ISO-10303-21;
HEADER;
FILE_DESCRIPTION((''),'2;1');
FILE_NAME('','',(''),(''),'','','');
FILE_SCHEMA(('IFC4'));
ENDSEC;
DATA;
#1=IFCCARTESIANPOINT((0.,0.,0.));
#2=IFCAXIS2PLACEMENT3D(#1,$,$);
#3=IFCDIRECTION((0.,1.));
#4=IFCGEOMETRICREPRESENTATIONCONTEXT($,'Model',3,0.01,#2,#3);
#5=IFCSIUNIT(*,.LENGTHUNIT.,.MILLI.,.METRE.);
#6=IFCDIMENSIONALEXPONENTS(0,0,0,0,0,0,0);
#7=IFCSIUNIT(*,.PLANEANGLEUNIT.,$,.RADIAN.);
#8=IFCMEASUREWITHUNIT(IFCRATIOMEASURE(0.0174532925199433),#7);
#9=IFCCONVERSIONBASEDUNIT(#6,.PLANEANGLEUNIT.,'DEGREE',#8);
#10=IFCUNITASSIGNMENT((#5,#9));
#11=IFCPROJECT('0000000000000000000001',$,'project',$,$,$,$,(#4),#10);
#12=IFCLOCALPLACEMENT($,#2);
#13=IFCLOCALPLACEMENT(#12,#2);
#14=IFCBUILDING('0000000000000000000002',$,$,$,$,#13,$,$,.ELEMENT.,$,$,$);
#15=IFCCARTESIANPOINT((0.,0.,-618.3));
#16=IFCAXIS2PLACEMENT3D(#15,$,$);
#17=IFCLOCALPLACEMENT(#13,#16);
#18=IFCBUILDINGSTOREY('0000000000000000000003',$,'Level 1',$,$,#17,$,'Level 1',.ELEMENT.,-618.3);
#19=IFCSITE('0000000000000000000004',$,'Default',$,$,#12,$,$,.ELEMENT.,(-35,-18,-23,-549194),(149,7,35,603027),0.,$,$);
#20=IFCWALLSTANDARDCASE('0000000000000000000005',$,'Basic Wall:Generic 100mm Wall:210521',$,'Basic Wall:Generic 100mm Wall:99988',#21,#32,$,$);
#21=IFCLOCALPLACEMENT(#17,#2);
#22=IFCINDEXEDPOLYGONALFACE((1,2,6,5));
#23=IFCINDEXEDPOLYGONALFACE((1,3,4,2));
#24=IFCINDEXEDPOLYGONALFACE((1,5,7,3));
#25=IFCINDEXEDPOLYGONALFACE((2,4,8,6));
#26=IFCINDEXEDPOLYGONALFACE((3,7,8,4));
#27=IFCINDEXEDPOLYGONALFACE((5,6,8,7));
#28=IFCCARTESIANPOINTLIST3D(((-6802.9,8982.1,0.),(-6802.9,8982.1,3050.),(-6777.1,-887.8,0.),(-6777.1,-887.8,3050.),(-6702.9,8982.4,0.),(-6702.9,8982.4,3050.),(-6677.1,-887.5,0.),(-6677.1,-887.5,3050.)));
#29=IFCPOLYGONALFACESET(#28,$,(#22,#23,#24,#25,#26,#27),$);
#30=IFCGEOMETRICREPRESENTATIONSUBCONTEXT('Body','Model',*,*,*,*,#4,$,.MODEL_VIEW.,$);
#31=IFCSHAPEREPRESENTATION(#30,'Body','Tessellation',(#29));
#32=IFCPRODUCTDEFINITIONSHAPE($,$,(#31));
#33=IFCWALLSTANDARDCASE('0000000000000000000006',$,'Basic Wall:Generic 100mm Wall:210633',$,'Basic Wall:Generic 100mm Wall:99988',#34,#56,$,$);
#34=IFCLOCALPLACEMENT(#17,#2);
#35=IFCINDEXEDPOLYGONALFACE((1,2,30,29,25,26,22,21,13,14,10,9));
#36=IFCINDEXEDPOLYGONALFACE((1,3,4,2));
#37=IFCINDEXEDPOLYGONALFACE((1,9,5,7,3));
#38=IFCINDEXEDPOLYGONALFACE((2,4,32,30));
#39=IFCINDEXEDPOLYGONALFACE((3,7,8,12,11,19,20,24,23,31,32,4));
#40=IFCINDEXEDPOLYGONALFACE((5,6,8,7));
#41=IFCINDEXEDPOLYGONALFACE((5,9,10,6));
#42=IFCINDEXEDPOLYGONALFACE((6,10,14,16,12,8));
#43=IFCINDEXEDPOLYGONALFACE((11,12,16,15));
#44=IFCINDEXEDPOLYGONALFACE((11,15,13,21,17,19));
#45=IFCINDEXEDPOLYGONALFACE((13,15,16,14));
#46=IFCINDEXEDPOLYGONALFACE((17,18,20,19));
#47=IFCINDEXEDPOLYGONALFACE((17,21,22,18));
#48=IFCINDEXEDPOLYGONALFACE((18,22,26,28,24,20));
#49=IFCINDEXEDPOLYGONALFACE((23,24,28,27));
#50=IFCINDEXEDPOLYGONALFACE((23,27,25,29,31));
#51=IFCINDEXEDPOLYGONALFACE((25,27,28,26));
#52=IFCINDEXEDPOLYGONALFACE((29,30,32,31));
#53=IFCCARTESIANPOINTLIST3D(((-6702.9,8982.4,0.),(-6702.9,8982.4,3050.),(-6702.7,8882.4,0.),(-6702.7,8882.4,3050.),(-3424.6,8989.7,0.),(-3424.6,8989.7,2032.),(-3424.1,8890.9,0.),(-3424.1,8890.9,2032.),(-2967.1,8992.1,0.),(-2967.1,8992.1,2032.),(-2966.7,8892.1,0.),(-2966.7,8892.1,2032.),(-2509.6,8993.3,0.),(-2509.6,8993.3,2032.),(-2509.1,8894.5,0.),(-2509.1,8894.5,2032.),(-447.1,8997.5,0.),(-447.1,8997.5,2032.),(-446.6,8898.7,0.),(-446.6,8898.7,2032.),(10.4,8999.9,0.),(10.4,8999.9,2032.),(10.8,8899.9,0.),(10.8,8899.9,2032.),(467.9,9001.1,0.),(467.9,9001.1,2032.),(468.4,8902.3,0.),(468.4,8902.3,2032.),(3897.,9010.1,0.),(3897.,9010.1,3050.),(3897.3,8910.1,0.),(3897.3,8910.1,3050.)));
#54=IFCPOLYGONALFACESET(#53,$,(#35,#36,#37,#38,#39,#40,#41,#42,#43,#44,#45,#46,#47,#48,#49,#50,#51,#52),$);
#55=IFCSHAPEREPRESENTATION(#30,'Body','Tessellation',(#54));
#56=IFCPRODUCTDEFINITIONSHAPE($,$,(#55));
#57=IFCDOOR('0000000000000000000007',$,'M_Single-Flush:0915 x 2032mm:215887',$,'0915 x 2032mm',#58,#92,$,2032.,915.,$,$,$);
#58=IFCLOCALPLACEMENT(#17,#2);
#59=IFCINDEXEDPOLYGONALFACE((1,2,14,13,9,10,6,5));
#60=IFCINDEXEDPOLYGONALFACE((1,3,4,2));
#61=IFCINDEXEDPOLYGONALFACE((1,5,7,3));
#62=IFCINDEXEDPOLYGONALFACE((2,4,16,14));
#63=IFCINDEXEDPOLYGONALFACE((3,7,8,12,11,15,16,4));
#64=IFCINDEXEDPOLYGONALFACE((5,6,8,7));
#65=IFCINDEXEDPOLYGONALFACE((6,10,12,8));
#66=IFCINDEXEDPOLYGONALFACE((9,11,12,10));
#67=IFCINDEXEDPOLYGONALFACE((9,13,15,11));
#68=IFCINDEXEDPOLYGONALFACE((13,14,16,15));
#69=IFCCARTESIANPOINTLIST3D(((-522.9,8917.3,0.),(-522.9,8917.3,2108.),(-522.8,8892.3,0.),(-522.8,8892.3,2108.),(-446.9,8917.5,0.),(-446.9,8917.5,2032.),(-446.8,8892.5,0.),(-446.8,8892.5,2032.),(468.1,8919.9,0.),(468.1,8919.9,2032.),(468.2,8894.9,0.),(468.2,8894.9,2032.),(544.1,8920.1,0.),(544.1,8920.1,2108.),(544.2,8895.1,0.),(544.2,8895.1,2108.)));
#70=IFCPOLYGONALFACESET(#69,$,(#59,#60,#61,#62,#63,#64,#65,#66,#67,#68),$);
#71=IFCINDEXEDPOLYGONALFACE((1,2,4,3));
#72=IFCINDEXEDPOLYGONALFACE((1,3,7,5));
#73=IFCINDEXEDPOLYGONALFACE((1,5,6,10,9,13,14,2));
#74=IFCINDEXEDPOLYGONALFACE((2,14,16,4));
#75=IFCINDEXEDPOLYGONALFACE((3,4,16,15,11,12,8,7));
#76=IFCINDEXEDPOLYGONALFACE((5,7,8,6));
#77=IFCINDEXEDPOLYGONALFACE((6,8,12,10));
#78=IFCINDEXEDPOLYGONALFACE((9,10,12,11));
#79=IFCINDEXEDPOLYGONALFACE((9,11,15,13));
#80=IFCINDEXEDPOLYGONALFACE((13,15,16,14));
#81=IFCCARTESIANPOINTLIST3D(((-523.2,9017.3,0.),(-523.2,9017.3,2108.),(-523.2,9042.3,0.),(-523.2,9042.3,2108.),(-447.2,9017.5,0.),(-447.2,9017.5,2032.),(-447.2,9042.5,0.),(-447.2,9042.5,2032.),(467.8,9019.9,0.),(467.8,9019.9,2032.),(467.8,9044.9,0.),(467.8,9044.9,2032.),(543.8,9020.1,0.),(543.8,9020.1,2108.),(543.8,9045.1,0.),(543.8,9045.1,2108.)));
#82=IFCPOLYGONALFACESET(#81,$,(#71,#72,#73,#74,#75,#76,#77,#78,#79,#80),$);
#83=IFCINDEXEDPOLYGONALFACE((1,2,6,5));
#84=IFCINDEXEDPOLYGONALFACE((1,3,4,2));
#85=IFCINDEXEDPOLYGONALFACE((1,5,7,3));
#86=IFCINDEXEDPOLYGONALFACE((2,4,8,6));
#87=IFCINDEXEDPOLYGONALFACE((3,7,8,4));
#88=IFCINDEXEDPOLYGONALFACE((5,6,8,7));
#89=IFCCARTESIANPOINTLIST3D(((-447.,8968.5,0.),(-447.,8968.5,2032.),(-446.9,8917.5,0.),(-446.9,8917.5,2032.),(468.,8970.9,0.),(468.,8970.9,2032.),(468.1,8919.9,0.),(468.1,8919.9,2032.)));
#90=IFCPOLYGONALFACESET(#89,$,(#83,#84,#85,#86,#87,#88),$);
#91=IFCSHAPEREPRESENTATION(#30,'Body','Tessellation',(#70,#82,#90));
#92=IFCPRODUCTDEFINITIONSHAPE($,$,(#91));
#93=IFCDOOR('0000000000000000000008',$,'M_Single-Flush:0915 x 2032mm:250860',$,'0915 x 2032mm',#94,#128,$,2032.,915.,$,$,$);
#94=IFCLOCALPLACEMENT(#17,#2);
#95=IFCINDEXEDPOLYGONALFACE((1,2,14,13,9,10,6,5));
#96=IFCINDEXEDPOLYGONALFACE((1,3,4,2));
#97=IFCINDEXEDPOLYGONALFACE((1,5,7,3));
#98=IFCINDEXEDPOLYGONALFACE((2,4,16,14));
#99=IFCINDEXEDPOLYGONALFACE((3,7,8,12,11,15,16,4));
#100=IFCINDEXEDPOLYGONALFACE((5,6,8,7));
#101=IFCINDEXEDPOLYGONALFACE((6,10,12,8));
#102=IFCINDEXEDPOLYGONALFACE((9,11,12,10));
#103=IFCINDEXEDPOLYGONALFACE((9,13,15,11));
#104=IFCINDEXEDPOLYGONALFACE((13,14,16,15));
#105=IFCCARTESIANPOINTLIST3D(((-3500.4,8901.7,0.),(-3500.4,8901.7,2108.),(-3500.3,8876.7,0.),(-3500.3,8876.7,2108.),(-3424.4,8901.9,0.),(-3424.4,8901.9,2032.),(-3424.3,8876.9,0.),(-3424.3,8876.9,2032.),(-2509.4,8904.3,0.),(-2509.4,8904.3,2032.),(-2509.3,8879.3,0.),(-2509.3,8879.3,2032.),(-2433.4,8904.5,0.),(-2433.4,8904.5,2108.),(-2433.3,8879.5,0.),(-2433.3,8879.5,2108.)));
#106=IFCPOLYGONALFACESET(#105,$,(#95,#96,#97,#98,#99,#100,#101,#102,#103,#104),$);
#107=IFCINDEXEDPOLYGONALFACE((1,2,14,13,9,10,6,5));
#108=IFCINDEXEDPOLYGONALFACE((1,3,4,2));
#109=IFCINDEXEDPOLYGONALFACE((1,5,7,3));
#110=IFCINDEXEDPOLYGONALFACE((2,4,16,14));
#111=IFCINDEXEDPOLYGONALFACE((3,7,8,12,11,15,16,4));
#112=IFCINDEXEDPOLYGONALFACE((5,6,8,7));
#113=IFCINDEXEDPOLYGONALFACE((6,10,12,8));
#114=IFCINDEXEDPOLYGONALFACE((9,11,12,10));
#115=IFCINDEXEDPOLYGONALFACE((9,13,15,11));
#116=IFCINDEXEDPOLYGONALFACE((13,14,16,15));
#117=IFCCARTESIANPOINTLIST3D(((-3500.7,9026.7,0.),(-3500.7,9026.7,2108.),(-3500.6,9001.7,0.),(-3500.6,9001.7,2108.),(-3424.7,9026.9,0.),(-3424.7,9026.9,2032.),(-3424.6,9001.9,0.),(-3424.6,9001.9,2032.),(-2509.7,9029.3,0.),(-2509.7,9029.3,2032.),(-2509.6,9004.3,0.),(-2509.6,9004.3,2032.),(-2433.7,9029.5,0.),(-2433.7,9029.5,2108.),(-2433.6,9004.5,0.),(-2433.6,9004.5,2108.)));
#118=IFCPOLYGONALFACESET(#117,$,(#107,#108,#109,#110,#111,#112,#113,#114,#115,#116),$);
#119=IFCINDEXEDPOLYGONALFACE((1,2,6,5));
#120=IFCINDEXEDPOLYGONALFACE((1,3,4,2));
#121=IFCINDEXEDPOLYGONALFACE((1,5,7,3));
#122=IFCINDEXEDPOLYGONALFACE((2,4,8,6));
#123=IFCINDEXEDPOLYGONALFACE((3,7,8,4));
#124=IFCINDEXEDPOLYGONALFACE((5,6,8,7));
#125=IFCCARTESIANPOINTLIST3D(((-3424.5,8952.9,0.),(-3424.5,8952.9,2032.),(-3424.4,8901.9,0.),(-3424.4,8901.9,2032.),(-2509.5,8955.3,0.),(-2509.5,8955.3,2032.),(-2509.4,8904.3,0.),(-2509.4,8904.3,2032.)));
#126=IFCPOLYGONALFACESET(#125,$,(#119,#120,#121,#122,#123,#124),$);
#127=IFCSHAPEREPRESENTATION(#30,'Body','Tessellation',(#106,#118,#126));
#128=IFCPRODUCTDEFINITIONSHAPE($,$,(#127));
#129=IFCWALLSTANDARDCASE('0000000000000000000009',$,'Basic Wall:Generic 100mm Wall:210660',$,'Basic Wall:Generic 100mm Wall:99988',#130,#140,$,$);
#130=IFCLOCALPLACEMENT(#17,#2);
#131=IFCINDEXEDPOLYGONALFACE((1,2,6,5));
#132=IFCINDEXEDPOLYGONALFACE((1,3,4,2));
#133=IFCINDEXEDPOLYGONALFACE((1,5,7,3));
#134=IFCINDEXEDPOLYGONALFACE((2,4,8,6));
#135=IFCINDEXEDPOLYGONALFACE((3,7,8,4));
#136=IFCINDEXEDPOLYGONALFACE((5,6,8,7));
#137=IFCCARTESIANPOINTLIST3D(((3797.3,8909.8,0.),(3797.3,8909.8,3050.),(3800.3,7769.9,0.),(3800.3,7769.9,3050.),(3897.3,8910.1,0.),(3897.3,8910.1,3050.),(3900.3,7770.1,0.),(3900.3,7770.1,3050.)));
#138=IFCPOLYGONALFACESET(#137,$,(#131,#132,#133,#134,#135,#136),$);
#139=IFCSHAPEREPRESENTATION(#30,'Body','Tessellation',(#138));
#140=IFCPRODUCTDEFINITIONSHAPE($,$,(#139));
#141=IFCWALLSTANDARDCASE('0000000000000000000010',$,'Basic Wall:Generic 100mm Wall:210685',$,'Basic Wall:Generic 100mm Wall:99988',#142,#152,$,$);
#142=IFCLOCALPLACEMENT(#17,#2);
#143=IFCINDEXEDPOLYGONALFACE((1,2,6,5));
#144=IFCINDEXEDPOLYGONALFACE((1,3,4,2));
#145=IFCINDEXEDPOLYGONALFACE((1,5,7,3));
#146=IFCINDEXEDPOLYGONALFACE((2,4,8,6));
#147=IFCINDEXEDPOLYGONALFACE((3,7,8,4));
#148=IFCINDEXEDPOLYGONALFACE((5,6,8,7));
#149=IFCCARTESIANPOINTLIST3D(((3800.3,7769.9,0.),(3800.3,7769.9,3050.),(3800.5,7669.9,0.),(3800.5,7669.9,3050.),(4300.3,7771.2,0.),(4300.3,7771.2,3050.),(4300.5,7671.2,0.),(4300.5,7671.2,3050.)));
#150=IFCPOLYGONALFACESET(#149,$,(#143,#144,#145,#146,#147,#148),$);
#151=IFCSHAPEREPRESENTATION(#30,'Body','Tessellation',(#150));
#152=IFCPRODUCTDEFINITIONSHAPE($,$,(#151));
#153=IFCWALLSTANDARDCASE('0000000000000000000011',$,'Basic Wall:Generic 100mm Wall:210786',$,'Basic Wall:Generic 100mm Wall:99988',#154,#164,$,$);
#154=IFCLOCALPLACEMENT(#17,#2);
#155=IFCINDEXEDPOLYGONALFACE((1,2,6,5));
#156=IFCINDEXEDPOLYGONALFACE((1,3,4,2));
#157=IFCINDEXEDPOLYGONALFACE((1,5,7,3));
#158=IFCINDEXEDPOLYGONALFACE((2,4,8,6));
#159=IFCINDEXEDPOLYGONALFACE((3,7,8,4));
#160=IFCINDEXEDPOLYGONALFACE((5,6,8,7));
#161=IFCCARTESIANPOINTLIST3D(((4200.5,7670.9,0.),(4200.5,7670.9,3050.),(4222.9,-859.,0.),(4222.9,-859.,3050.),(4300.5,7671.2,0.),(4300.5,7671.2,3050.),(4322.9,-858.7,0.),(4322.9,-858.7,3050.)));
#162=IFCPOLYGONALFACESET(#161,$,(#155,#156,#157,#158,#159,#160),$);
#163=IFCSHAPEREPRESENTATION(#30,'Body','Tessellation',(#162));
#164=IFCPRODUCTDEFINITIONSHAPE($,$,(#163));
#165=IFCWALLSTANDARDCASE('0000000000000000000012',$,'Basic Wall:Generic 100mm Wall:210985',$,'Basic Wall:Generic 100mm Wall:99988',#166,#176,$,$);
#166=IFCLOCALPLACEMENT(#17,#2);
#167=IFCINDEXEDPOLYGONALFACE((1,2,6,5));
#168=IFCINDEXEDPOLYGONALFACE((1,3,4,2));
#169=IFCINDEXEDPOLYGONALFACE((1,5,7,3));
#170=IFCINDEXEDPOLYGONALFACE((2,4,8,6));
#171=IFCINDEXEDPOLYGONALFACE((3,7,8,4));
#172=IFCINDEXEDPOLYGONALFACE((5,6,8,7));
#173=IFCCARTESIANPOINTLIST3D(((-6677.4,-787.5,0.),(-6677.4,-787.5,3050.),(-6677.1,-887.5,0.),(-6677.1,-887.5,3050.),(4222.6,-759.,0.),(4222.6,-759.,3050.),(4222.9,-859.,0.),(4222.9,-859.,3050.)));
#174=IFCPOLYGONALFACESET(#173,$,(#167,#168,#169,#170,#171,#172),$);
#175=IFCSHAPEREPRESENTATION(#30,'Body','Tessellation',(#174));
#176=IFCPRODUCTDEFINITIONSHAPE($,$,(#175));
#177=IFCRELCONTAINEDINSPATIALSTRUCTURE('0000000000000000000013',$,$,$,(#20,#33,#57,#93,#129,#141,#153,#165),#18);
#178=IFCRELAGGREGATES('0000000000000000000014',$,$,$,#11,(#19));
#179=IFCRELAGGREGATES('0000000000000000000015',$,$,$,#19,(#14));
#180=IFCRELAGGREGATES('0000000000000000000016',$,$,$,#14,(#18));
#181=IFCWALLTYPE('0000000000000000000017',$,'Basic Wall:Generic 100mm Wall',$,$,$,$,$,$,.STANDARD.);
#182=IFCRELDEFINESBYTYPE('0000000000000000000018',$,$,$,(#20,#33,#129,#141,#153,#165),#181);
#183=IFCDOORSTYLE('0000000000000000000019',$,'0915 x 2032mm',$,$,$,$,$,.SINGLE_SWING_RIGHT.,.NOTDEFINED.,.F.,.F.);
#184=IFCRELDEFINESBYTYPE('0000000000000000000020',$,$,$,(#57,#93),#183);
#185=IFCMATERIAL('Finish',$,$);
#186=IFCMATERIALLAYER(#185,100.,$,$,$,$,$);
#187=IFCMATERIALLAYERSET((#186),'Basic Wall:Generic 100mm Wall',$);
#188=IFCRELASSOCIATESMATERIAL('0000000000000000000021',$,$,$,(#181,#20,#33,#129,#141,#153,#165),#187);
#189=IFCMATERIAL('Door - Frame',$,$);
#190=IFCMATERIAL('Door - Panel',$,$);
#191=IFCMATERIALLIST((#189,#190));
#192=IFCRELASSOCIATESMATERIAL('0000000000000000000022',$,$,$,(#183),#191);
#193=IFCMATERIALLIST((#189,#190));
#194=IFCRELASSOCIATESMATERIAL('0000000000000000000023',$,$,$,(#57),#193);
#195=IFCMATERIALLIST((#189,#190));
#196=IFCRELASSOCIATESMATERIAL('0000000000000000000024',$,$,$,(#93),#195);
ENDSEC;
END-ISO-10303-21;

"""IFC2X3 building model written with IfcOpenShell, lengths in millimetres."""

from ifc_helpers import new_model, entity, si_unit, converted_unit, direction, frame, frame_2d, origin, origin_2d_with_axis, place, context, subcontext, project, spatial, polyline, rectangle, outline, extrude, source, transform, mapped, material, material_list, layer, layer_set, layer_usage, type_object, type_shapes, element, fill, save


model = new_model("IFC2X3")

# Units and contexts
model_context = context("Model", 3, precision=0.01, world=origin(), true_north=direction((0.0, 1.0)))
body_context = subcontext(model_context, "Body", "Model", "MODEL_VIEW")
ifc_project = project(units=[si_unit("LENGTHUNIT", "METRE", prefix="MILLI"), converted_unit("PLANEANGLEUNIT", "DEGREE", entity("IfcRatioMeasure", 0.0174532925199433), si_unit("PLANEANGLEUNIT", "RADIAN"), dimensions=[0, 0, 0, 0, 0, 0, 0])], contexts=[model_context])

# Site, building, storey
site_placement = place(None, origin())
site = spatial("IfcSite", under=ifc_project, at=site_placement, Name="Default", CompositionType="ELEMENT", RefLatitude=(-35, -18, -23, -549194), RefLongitude=(149, 7, 35, 603027), RefElevation=0.0)
building_placement = place(site_placement, origin())
building = spatial("IfcBuilding", under=site, at=building_placement, CompositionType="ELEMENT")
storey_placement = place(building_placement, frame((0.0, 0.0, -618.3)))
storey = spatial("IfcBuildingStorey", under=building, at=storey_placement, Name="Level 1", LongName="Level 1", CompositionType="ELEMENT", Elevation=-618.3)

# Wall
ifc_material_1 = material(Name="Finish")
ifc_layer_1 = layer(ifc_material_1, 100.0)
ifc_layer_set_1 = layer_set([ifc_layer_1], Name="Basic Wall:Generic 100mm Wall")
ifc_layer_usage_1 = layer_usage(ifc_layer_set_1, "AXIS2", "NEGATIVE", 50.0)
wall_type = type_object("IfcWallType", Name="Basic Wall:Generic 100mm Wall", PredefinedType="STANDARD", material=ifc_layer_set_1)
wall_1_placement = place(storey_placement, frame((-6727.1, -887.7, 0.0), z_axis=(0.0, 0.0, 1.0), x_axis=(-0.002618, 0.999997, 0.0)))
element("IfcWallStandardCase", 1, at=wall_1_placement, inside=storey, type_object=wall_type, material=ifc_layer_usage_1, Name="Basic Wall:Generic 100mm Wall:210521", ObjectType="Basic Wall:Generic 100mm Wall:99988", context=body_context, shape_type="SweptSolid", body=[
    extrude(rectangle(XDim=9869.9, YDim=100.0, at=frame_2d((4935.0, 0.0), x_axis=(-1.0, 0.0))), origin(), (0.0, 0.0, 1.0), 3050.0),
])

# Wall, openings, doors
ifc_layer_usage_2 = layer_usage(ifc_layer_set_1, "AXIS2", "NEGATIVE", 50.0)
wall_2_placement = place(storey_placement, frame((-6702.8, 8932.4, 0.0), z_axis=(0.0, 0.0, 1.0), x_axis=(0.999997, 0.002618, 0.0)))
wall_2 = element("IfcWallStandardCase", 2, at=wall_2_placement, inside=storey, type_object=wall_type, material=ifc_layer_usage_2, Name="Basic Wall:Generic 100mm Wall:210633", ObjectType="Basic Wall:Generic 100mm Wall:99988", context=body_context, shape_type="SweptSolid", body=[
    extrude(rectangle(XDim=10600.0, YDim=100.0, at=frame_2d((5300.0, 0.0), x_axis=(-1.0, 0.0))), origin(), (0.0, 0.0, 1.0), 3050.0),
])
opening_1_placement = place(wall_2_placement, frame((7170.8, 51.2, 0.0)))
opening_1 = element("IfcOpeningElement", 3, at=opening_1_placement, cuts=wall_2, ObjectType="Opening", context=body_context, shape_type="SweptSolid", body=[
    extrude(rectangle(XDim=915.0, YDim=2032.0, at=frame_2d((1016.0, 457.5), x_axis=(0.0, 1.0))), frame((0.0, 0.0, 0.0), z_axis=(0.002618, -0.999997, 0.0), x_axis=(0.0, 0.0, 1.0)), (0.0, 0.0, 1.0), 100.0),
])
opening_2_placement = place(wall_2_placement, frame((4193.4, 51.2, 0.0)))
opening_2 = element("IfcOpeningElement", 4, at=opening_2_placement, cuts=wall_2, ObjectType="Opening", context=body_context, shape_type="SweptSolid", body=[
    extrude(rectangle(XDim=915.0, YDim=2032.0, at=frame_2d((1016.0, 457.5), x_axis=(0.0, 1.0))), frame((0.0, 0.0, 0.0), z_axis=(0.002618, -0.999997, 0.0), x_axis=(0.0, 0.0, 1.0)), (0.0, 0.0, 1.0), 100.0),
])
ifc_material_2 = material(Name="Door - Frame")
ifc_material_3 = material(Name="Door - Panel")
ifc_material_list_1 = material_list([ifc_material_2, ifc_material_3])
ifc_material_list_2 = material_list([ifc_material_2, ifc_material_3])
door_style = type_object("IfcDoorStyle", Name="0915 x 2032mm", ConstructionType="NOTDEFINED", OperationType="SINGLE_SWING_RIGHT", ParameterTakesPrecedence=False, Sizeable=False, material=ifc_material_list_2)
shared_shape = source(origin(), body_context, "Body", "SweptSolid", [
    extrude(outline(polyline([(-533.5, -1073.0), (533.5, -1073.0), (533.5, 1035.0), (457.5, 1035.0), (457.5, -997.0), (-457.5, -997.0), (-457.5, 1035.0), (-533.5, 1035.0), (-533.5, -1073.0)])), frame((457.5, 100.0, 1035.0), z_axis=(0.0, 1.0, 0.0), x_axis=(1.0, 0.0, 0.0)), (0.0, 0.0, 1.0), 25.0),
    extrude(outline(polyline([(-1073.0, -533.5), (1035.0, -533.5), (1035.0, -457.5), (-997.0, -457.5), (-997.0, 457.5), (1035.0, 457.5), (1035.0, 533.5), (-1073.0, 533.5), (-1073.0, -533.5)])), frame((457.5, -25.0, 1035.0), z_axis=(0.0, 1.0, 0.0), x_axis=(0.0, 0.0, -1.0)), (0.0, 0.0, 1.0), 25.0),
    extrude(rectangle(XDim=51.0, YDim=915.0, at=origin_2d_with_axis()), frame((457.5, 74.5, 0.0), z_axis=(0.0, 0.0, 1.0), x_axis=(0.0, 1.0, 0.0)), (0.0, 0.0, 1.0), 2032.0),
])
type_shapes(door_style, [shared_shape])
door_1_placement = place(opening_1_placement, frame((0.0, 17.6, 0.0), z_axis=(0.0, 0.0, 1.0), x_axis=(-1.0, 0.0, 0.0)))
door_1 = element("IfcDoor", 5, at=door_1_placement, inside=storey, type_object=door_style, material=ifc_material_list_1, Name="M_Single-Flush:0915 x 2032mm:215887", ObjectType="0915 x 2032mm", OverallHeight=2032.0, OverallWidth=915.0, context=body_context, shape_type="MappedRepresentation", body=[
    mapped(shared_shape, transform((0.0, 0.0, 0.0), scale=1.0)),
])
fill(opening_1, door_1)
ifc_material_list_3 = material_list([ifc_material_2, ifc_material_3])
door_2_placement = place(opening_2_placement, frame((0.0, 9.8, 0.0), z_axis=(0.0, 0.0, 1.0), x_axis=(-1.0, 0.0, 0.0)))
door_2 = element("IfcDoor", 6, at=door_2_placement, inside=storey, type_object=door_style, material=ifc_material_list_3, Name="M_Single-Flush:0915 x 2032mm:250860", ObjectType="0915 x 2032mm", OverallHeight=2032.0, OverallWidth=915.0, context=body_context, shape_type="MappedRepresentation", body=[
    mapped(shared_shape, transform((0.0, 0.0, 0.0), scale=1.0)),
])
fill(opening_2, door_2)

# Walls
ifc_layer_usage_3 = layer_usage(ifc_layer_set_1, "AXIS2", "NEGATIVE", 50.0)
wall_3_placement = place(storey_placement, frame((3847.3, 8910.0, 0.0), z_axis=(0.0, 0.0, 1.0), x_axis=(0.002618, -0.999997, 0.0)))
element("IfcWallStandardCase", 7, at=wall_3_placement, inside=storey, type_object=wall_type, material=ifc_layer_usage_3, Name="Basic Wall:Generic 100mm Wall:210660", ObjectType="Basic Wall:Generic 100mm Wall:99988", context=body_context, shape_type="SweptSolid", body=[
    extrude(rectangle(XDim=1140.0, YDim=100.0, at=frame_2d((570.0, 0.0), x_axis=(-1.0, 0.0))), origin(), (0.0, 0.0, 1.0), 3050.0),
])
ifc_layer_usage_4 = layer_usage(ifc_layer_set_1, "AXIS2", "NEGATIVE", 50.0)
wall_4_placement = place(storey_placement, frame((3800.4, 7719.9, 0.0), z_axis=(0.0, 0.0, 1.0), x_axis=(0.999997, 0.002618, 0.0)))
element("IfcWallStandardCase", 8, at=wall_4_placement, inside=storey, type_object=wall_type, material=ifc_layer_usage_4, Name="Basic Wall:Generic 100mm Wall:210685", ObjectType="Basic Wall:Generic 100mm Wall:99988", context=body_context, shape_type="SweptSolid", body=[
    extrude(rectangle(XDim=500.0, YDim=100.0, at=frame_2d((250.0, 0.0), x_axis=(-1.0, 0.0))), origin(), (0.0, 0.0, 1.0), 3050.0),
])
ifc_layer_usage_5 = layer_usage(ifc_layer_set_1, "AXIS2", "NEGATIVE", 50.0)
wall_5_placement = place(storey_placement, frame((4250.5, 7671.0, 0.0), z_axis=(0.0, 0.0, 1.0), x_axis=(0.002618, -0.999997, 0.0)))
element("IfcWallStandardCase", 9, at=wall_5_placement, inside=storey, type_object=wall_type, material=ifc_layer_usage_5, Name="Basic Wall:Generic 100mm Wall:210786", ObjectType="Basic Wall:Generic 100mm Wall:99988", context=body_context, shape_type="SweptSolid", body=[
    extrude(rectangle(XDim=8529.9, YDim=100.0, at=frame_2d((4265.0, 0.0), x_axis=(-1.0, 0.0))), origin(), (0.0, 0.0, 1.0), 3050.0),
])
ifc_layer_usage_6 = layer_usage(ifc_layer_set_1, "AXIS2", "NEGATIVE", 50.0)
wall_6_placement = place(storey_placement, frame((4222.7, -809.0, 0.0), z_axis=(0.0, 0.0, 1.0), x_axis=(-0.999997, -0.002618, 0.0)))
element("IfcWallStandardCase", 10, at=wall_6_placement, inside=storey, type_object=wall_type, material=ifc_layer_usage_6, Name="Basic Wall:Generic 100mm Wall:210985", ObjectType="Basic Wall:Generic 100mm Wall:99988", context=body_context, shape_type="SweptSolid", body=[
    extrude(rectangle(XDim=10900.0, YDim=100.0, at=frame_2d((5450.0, 0.0), x_axis=(-1.0, 0.0))), origin(), (0.0, 0.0, 1.0), 3050.0),
])

save(model, "model.ifc")
